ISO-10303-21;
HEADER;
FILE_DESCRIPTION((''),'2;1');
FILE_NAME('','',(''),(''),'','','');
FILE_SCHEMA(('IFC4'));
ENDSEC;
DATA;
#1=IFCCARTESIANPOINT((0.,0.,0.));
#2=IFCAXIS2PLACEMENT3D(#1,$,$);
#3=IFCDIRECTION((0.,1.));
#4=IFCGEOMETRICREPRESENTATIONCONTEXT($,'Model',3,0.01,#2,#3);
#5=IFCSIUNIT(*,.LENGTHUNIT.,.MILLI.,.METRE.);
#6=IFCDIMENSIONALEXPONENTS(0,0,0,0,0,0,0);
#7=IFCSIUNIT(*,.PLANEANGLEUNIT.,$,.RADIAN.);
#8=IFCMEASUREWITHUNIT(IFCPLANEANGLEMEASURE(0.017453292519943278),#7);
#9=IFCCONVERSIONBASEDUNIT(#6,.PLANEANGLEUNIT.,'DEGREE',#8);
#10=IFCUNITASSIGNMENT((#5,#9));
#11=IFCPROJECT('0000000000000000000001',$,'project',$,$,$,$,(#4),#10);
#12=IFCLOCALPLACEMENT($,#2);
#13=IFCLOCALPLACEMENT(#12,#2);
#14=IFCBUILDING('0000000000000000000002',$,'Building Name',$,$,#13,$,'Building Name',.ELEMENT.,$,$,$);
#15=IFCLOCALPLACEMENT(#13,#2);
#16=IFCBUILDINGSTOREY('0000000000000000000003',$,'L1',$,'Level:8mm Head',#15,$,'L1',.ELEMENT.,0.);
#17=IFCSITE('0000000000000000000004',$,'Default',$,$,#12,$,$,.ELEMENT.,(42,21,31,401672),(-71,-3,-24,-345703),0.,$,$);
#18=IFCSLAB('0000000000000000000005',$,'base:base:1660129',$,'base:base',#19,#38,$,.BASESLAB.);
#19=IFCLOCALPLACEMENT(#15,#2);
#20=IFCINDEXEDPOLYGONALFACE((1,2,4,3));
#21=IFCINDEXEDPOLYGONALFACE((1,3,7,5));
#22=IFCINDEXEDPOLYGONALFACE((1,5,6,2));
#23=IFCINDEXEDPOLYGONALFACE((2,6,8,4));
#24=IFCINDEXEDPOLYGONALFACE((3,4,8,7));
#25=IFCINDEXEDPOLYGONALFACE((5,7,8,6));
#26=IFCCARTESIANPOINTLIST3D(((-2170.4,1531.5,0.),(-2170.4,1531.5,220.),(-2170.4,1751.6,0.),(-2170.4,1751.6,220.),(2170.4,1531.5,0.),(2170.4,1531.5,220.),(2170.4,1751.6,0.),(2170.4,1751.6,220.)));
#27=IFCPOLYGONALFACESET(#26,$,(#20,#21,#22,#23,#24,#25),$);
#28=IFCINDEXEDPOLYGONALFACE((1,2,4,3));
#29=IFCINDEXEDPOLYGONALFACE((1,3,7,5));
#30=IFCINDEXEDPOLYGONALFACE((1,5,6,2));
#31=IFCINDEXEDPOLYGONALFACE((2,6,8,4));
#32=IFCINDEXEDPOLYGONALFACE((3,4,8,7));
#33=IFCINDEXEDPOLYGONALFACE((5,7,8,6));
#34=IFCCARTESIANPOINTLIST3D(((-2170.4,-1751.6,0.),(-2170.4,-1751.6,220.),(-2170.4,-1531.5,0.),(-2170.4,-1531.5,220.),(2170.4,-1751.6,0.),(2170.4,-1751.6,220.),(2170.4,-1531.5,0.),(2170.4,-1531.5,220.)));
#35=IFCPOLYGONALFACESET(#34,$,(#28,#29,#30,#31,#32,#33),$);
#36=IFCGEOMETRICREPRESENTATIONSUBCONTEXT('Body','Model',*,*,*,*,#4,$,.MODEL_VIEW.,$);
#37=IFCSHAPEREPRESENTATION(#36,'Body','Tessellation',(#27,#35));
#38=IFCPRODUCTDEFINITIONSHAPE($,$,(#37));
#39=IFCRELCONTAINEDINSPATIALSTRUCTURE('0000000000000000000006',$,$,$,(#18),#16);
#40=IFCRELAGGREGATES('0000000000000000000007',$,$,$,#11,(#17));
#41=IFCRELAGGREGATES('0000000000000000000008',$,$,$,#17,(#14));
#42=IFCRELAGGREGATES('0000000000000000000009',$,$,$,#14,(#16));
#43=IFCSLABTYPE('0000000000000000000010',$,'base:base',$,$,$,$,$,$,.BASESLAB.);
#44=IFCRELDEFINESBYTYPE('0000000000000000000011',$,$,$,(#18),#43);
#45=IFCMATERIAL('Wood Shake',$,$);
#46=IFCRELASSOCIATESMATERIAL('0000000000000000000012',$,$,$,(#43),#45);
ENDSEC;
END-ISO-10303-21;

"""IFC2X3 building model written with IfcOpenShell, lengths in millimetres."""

from ifc_helpers import new_model, entity, si_unit, converted_unit, direction, frame, origin, origin_2d_with_axis, place, context, subcontext, project, spatial, rectangle, extrude, material, type_object, element, save


model = new_model("IFC2X3")

# Units and contexts
model_context = context("Model", 3, precision=0.01, world=origin(), true_north=direction((0.0, 1.0)))
body_context = subcontext(model_context, "Body", "Model", "MODEL_VIEW")
ifc_project = project(units=[si_unit("LENGTHUNIT", "METRE", prefix="MILLI"), converted_unit("PLANEANGLEUNIT", "DEGREE", entity("IfcPlaneAngleMeasure", 0.017453292519943278), si_unit("PLANEANGLEUNIT", "RADIAN"), dimensions=[0, 0, 0, 0, 0, 0, 0])], contexts=[model_context])

# Site, building, storey
site_placement = place(None, origin())
site = spatial("IfcSite", under=ifc_project, at=site_placement, Name="Default", CompositionType="ELEMENT", RefLatitude=(42, 21, 31, 401672), RefLongitude=(-71, -3, -24, -345703), RefElevation=0.0)
building_placement = place(site_placement, origin())
building = spatial("IfcBuilding", under=site, at=building_placement, Name="Building Name", LongName="Building Name", CompositionType="ELEMENT")
storey_placement = place(building_placement, origin())
storey = spatial("IfcBuildingStorey", under=building, at=storey_placement, Name="L1", ObjectType="Level:8mm Head", LongName="L1", CompositionType="ELEMENT", Elevation=0.0)

# Slab
ifc_material_1 = material(Name="Wood Shake")
slab_type = type_object("IfcSlabType", Name="base:base", PredefinedType="BASESLAB", material=ifc_material_1)
slab_placement = place(storey_placement, origin())
element("IfcSlab", 1, at=slab_placement, inside=storey, type_object=slab_type, Name="base:base:1660129", ObjectType="base:base", PredefinedType="BASESLAB", context=body_context, shape_type="SweptSolid", body=[
    extrude(rectangle(XDim=220.0, YDim=4340.9, at=origin_2d_with_axis()), frame((0.0, 1641.6, 0.0), z_axis=(0.0, 0.0, 1.0), x_axis=(0.0, -1.0, 0.0)), (0.0, 0.0, 1.0), 220.0),
    extrude(rectangle(XDim=4340.9, YDim=220.0, at=origin_2d_with_axis()), frame((0.0, -1641.6, 0.0)), (0.0, 0.0, 1.0), 220.0),
])

save(model, "model.ifc")
